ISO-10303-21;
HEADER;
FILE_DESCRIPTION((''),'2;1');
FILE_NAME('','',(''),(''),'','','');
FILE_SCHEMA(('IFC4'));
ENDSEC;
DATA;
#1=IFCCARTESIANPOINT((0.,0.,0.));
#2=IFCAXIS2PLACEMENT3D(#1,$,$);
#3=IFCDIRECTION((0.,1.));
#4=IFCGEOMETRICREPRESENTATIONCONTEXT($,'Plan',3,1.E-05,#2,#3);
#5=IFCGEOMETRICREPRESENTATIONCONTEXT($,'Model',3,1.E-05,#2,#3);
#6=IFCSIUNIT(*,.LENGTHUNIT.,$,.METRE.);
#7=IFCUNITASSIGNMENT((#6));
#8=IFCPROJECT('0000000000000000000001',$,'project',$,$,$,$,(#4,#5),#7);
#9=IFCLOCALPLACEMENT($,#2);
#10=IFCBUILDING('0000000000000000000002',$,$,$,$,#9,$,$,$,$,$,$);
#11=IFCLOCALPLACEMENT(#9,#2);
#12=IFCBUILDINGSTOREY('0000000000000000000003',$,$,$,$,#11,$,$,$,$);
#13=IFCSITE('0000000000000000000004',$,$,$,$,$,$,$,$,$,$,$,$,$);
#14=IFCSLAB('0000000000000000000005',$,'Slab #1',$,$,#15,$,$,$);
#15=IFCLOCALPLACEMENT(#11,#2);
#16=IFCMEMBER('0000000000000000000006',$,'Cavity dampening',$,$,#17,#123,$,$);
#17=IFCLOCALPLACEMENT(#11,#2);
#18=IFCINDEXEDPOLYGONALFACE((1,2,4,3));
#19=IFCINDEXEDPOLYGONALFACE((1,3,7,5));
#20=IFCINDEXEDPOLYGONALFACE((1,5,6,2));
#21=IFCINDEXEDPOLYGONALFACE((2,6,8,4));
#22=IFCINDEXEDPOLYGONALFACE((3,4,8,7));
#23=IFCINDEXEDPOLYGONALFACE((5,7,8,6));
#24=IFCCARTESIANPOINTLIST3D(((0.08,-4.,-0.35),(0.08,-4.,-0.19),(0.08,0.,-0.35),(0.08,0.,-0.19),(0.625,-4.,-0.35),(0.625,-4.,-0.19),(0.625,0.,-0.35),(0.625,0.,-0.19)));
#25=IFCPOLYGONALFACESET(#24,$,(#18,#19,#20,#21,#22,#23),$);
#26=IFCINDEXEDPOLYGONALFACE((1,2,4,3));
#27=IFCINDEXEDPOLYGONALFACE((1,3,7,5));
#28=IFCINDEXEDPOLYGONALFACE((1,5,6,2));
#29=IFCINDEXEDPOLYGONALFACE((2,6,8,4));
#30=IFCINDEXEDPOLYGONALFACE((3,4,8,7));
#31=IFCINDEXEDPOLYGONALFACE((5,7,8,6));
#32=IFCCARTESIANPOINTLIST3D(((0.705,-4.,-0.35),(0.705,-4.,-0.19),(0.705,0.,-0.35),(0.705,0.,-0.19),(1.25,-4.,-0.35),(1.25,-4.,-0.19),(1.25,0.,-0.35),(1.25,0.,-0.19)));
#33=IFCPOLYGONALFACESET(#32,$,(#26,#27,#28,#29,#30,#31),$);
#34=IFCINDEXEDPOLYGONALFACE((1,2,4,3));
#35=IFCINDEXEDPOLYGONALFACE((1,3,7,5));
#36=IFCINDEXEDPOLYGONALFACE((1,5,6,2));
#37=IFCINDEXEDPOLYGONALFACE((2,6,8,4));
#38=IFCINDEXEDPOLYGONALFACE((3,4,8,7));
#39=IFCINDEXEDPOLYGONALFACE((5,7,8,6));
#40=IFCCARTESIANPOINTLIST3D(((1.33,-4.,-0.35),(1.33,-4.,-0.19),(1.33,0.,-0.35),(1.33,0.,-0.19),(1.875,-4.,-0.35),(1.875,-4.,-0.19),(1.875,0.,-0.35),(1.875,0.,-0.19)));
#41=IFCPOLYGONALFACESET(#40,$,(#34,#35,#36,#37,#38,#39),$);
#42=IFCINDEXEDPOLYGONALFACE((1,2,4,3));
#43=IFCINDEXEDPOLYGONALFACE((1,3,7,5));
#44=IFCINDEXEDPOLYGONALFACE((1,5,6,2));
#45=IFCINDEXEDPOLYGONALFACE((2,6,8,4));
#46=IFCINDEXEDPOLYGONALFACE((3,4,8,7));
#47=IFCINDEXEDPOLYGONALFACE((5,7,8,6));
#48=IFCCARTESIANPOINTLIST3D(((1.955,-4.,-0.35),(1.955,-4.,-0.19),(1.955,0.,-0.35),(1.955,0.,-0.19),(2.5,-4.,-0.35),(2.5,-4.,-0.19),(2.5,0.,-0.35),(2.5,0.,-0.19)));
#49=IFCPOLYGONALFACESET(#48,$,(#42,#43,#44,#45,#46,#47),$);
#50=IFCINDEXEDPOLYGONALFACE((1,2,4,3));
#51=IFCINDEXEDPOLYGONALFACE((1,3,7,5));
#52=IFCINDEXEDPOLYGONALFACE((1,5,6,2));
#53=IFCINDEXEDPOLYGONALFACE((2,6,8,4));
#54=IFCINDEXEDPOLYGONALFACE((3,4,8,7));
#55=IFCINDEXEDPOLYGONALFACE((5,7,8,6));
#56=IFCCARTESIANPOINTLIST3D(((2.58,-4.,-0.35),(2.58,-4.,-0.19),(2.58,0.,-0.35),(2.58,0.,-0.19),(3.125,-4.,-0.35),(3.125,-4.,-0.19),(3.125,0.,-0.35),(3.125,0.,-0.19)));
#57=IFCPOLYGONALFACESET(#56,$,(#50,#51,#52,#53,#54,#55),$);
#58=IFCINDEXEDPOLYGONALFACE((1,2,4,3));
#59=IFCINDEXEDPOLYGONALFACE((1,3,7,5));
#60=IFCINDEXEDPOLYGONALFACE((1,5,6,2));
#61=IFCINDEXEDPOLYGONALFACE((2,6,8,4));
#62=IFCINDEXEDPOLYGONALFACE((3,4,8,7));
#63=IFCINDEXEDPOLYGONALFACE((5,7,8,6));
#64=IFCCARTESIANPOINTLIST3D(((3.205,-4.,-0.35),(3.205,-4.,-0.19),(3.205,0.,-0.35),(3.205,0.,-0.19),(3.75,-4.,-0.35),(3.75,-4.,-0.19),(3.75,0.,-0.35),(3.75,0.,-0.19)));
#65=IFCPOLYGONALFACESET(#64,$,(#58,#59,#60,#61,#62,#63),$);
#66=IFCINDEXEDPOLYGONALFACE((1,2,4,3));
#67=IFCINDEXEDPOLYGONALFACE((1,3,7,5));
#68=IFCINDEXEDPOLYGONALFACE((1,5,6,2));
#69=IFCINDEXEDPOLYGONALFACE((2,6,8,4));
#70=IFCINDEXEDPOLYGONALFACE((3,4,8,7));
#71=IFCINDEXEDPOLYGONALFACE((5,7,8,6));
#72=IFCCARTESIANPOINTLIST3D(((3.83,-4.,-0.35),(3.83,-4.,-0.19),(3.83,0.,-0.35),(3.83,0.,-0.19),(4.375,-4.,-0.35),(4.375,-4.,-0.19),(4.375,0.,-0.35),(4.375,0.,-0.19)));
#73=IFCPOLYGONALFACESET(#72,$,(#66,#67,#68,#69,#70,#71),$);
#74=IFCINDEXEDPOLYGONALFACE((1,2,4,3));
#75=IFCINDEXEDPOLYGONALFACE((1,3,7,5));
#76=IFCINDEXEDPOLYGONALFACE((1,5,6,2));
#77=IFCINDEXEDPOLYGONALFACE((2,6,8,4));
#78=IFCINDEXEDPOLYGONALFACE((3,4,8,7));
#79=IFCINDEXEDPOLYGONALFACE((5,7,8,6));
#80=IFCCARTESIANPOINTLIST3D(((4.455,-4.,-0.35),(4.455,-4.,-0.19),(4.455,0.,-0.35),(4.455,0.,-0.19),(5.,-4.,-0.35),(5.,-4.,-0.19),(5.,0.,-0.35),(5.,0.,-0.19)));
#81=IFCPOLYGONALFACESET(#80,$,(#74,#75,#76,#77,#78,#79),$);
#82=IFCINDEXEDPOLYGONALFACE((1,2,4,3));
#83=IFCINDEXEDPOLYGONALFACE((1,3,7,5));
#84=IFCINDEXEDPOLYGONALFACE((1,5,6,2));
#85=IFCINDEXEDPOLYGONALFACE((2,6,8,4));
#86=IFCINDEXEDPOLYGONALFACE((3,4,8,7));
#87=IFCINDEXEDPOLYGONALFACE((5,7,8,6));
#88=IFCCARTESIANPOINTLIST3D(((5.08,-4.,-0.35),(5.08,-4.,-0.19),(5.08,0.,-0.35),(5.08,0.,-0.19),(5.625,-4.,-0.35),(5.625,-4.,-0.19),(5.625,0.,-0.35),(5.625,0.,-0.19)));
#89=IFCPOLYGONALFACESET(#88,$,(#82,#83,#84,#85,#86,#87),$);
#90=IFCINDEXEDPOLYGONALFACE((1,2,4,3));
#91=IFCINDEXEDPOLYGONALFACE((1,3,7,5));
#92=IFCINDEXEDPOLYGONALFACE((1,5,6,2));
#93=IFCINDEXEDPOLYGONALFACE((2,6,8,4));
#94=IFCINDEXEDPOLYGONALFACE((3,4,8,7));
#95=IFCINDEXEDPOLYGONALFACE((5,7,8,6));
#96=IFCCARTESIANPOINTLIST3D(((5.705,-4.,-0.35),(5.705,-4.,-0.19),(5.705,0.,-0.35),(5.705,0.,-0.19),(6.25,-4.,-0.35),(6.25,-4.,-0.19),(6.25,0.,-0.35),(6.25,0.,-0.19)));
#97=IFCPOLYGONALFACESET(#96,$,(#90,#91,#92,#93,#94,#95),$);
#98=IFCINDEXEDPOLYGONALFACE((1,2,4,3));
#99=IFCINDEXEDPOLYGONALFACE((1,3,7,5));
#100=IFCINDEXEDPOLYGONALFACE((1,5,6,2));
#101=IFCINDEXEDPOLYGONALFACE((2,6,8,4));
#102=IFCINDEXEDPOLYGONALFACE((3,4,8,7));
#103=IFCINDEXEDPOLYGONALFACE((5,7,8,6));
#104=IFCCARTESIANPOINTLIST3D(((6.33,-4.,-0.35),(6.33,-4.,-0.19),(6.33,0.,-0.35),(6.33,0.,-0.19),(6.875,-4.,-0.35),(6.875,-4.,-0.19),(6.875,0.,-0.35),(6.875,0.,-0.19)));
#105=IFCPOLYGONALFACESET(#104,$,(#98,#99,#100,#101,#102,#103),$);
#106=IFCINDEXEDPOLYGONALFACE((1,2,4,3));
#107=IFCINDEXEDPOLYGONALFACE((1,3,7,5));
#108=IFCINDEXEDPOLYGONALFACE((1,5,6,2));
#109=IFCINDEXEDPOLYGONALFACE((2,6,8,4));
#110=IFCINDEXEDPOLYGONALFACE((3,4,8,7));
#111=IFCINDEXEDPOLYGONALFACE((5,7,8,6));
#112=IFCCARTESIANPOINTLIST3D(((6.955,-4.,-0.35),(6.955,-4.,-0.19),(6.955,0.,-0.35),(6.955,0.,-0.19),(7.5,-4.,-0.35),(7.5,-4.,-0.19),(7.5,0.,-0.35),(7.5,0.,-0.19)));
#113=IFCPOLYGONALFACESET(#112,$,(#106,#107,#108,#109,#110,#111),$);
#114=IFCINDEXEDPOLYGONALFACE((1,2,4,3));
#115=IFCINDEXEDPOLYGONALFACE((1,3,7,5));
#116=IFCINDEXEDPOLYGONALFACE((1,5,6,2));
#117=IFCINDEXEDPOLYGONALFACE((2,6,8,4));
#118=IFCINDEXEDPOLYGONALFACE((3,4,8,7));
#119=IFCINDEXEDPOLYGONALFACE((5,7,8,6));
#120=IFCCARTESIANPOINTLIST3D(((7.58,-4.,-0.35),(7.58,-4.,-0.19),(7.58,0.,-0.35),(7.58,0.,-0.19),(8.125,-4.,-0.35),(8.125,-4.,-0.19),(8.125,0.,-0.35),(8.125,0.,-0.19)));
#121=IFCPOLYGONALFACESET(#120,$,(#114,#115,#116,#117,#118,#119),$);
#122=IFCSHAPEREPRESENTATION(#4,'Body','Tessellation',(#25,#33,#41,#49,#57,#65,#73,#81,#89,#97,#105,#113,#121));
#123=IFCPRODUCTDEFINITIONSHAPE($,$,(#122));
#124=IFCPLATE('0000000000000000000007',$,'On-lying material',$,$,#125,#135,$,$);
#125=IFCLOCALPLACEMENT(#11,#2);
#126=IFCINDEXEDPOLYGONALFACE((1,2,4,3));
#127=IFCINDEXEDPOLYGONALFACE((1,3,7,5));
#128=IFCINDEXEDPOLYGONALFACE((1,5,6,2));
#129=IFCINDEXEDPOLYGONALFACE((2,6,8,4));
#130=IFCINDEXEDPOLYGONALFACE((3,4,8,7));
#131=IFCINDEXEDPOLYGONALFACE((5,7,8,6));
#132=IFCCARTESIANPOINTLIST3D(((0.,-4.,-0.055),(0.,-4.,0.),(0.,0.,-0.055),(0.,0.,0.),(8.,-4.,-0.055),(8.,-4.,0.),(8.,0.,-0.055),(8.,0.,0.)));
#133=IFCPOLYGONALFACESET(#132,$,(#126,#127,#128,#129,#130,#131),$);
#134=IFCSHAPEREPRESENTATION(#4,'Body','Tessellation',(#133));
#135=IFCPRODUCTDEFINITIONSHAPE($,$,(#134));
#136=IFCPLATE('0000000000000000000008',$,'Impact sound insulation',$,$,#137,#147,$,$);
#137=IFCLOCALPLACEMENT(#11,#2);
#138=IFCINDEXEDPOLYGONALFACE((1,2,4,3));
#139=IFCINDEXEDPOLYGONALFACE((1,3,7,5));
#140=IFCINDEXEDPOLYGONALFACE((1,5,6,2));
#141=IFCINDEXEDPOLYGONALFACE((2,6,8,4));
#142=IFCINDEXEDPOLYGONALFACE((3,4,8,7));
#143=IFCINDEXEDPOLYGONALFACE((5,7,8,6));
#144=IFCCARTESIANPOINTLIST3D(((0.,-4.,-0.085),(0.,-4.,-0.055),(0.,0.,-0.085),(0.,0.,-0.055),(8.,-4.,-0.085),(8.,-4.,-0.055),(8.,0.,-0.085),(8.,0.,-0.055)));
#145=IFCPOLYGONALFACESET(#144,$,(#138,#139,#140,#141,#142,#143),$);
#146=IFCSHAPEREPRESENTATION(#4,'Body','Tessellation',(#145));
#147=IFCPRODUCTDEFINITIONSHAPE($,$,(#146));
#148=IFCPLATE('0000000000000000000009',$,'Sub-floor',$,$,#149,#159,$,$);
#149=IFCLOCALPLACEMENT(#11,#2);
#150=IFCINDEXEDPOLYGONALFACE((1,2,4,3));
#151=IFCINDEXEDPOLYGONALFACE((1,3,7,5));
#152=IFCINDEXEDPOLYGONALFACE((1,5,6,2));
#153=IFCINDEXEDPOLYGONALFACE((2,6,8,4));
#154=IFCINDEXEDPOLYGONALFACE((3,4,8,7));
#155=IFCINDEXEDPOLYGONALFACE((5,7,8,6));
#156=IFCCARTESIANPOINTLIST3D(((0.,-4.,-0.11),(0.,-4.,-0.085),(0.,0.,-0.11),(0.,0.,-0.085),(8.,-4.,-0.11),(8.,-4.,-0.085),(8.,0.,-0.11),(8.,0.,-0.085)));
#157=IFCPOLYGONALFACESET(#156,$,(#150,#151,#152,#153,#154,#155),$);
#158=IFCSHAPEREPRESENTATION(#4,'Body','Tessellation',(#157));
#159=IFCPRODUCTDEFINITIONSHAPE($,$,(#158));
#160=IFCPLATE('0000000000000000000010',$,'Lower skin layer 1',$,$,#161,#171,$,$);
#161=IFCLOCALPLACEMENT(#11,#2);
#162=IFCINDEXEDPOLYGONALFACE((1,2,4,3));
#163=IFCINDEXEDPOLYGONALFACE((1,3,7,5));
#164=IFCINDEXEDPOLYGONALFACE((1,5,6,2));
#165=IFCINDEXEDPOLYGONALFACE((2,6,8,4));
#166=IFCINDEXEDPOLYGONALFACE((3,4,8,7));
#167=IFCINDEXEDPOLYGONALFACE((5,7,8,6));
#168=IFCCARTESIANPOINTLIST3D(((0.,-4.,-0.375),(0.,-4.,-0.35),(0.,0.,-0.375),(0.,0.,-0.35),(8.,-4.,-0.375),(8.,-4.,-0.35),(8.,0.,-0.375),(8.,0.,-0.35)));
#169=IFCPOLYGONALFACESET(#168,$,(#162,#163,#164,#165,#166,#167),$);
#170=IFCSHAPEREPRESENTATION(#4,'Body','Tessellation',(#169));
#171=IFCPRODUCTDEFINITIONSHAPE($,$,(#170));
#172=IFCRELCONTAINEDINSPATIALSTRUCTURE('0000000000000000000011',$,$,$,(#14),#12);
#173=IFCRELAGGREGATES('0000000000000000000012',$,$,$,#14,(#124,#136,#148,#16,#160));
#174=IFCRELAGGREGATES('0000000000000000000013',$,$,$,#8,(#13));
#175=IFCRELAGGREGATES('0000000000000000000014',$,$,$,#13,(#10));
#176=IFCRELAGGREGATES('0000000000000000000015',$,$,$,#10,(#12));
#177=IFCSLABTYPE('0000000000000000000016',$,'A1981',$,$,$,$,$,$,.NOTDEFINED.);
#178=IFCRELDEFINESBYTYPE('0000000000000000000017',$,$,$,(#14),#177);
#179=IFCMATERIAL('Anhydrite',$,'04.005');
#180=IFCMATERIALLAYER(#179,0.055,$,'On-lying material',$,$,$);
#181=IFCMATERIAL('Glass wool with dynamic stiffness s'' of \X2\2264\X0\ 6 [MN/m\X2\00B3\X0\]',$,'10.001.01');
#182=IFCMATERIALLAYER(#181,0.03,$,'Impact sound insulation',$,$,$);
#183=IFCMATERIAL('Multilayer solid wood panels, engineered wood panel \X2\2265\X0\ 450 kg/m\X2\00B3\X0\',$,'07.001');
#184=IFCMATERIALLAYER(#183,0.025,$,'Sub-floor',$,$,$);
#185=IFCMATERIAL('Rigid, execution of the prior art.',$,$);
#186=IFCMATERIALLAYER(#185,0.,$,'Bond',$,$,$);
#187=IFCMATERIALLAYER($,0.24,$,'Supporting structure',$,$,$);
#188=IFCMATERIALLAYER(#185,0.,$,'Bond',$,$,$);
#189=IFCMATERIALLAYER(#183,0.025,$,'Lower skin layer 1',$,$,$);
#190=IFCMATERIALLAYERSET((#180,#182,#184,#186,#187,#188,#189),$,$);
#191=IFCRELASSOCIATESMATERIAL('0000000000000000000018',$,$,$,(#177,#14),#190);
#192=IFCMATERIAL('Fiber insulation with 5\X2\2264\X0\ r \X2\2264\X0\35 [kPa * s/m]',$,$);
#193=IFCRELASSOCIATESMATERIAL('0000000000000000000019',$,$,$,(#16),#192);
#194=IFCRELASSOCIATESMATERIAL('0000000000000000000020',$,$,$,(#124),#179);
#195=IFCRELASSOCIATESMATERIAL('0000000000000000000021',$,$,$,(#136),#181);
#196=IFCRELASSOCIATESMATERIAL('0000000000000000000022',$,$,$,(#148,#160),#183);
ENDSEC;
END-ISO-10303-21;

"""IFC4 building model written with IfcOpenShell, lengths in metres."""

from ifc_helpers import new_model, si_unit, direction, frame, frame_2d, origin, origin_with_axes, place, context, project, spatial, rectangle, extrude, material, layer, layer_set, type_object, element, aggregate, save


model = new_model("IFC4")

# Units and contexts
plan_context = context("Plan", 3, precision=1e-05, world=origin(), true_north=direction((0.0, 1.0)))
model_context = context("Model", 3, precision=1e-05, world=origin(), true_north=direction((0.0, 1.0)))
ifc_project = project(units=[si_unit("LENGTHUNIT", "METRE")], contexts=[plan_context, model_context])

# Site, building, storey
site = spatial("IfcSite", under=ifc_project)
building_placement = place(None, origin())
building = spatial("IfcBuilding", under=site, at=building_placement)
storey_placement = place(building_placement, origin())
storey = spatial("IfcBuildingStorey", under=building, at=storey_placement)

# Slab, member, plates
ifc_material_1 = material(Name="Anhydrite", Category="04.005")
ifc_layer_1 = layer(ifc_material_1, 0.055, Name="On-lying material")
ifc_material_2 = material(Name="Glass wool with dynamic stiffness s' of ≤ 6 [MN/m³]", Category="10.001.01")
ifc_layer_2 = layer(ifc_material_2, 0.03, Name="Impact sound insulation")
ifc_material_3 = material(Name="Multilayer solid wood panels, engineered wood panel ≥ 450 kg/m³", Category="07.001")
ifc_layer_3 = layer(ifc_material_3, 0.025, Name="Sub-floor")
ifc_material_4 = material(Name="Rigid, execution of the prior art.")
ifc_layer_4 = layer(ifc_material_4, 0.0, Name="Bond")
ifc_layer_5 = layer(None, 0.24, Name="Supporting structure")
ifc_layer_6 = layer(ifc_material_4, 0.0, Name="Bond")
ifc_layer_7 = layer(ifc_material_3, 0.025, Name="Lower skin layer 1")
ifc_layer_set = layer_set([ifc_layer_1, ifc_layer_2, ifc_layer_3, ifc_layer_4, ifc_layer_5, ifc_layer_6, ifc_layer_7])
slab_type = type_object("IfcSlabType", Name="A1981", PredefinedType="NOTDEFINED", material=ifc_layer_set)
slab_placement = place(None, frame((0.0, 0.0, 0.0), z_axis=(0.0, 0.0, -1.0), x_axis=(1.0, 0.0, 0.0)))
slab = element("IfcSlab", 1, at=slab_placement, inside=storey, type_object=slab_type, material=ifc_layer_set, Name="Slab #1")
ifc_material_5 = material(Name="Fiber insulation with 5≤ r ≤35 [kPa * s/m]")
member_1_placement = place(slab_placement, origin())
member_1 = element("IfcMember", 2, at=member_1_placement, material=ifc_material_5, Name="Cavity dampening", context=plan_context, shape_type="SweptSolid", body=[
    extrude(rectangle(XDim=0.545, YDim=0.16, at=frame_2d((0.2725, 0.08), x_axis=(1.0, 0.0))), frame((0.08, 4.0, 0.19), z_axis=(0.0, -1.0, 0.0), x_axis=(1.0, 0.0, 0.0)), (0.0, 0.0, 1.0), 4.0),
    extrude(rectangle(XDim=0.545, YDim=0.16, at=frame_2d((0.2725, 0.08), x_axis=(1.0, 0.0))), frame((0.705, 4.0, 0.19), z_axis=(0.0, -1.0, 0.0), x_axis=(1.0, 0.0, 0.0)), (0.0, 0.0, 1.0), 4.0),
    extrude(rectangle(XDim=0.545, YDim=0.16, at=frame_2d((0.2725, 0.08), x_axis=(1.0, 0.0))), frame((1.33, 4.0, 0.19), z_axis=(0.0, -1.0, 0.0), x_axis=(1.0, 0.0, 0.0)), (0.0, 0.0, 1.0), 4.0),
    extrude(rectangle(XDim=0.545, YDim=0.16, at=frame_2d((0.2725, 0.08), x_axis=(1.0, 0.0))), frame((1.955, 4.0, 0.19), z_axis=(0.0, -1.0, 0.0), x_axis=(1.0, 0.0, 0.0)), (0.0, 0.0, 1.0), 4.0),
    extrude(rectangle(XDim=0.545, YDim=0.16, at=frame_2d((0.2725, 0.08), x_axis=(1.0, 0.0))), frame((2.58, 4.0, 0.19), z_axis=(0.0, -1.0, 0.0), x_axis=(1.0, 0.0, 0.0)), (0.0, 0.0, 1.0), 4.0),
    extrude(rectangle(XDim=0.545, YDim=0.16, at=frame_2d((0.2725, 0.08), x_axis=(1.0, 0.0))), frame((3.205, 4.0, 0.19), z_axis=(0.0, -1.0, 0.0), x_axis=(1.0, 0.0, 0.0)), (0.0, 0.0, 1.0), 4.0),
    extrude(rectangle(XDim=0.545, YDim=0.16, at=frame_2d((0.2725, 0.08), x_axis=(1.0, 0.0))), frame((3.83, 4.0, 0.19), z_axis=(0.0, -1.0, 0.0), x_axis=(1.0, 0.0, 0.0)), (0.0, 0.0, 1.0), 4.0),
    extrude(rectangle(XDim=0.545, YDim=0.16, at=frame_2d((0.2725, 0.08), x_axis=(1.0, 0.0))), frame((4.455, 4.0, 0.19), z_axis=(0.0, -1.0, 0.0), x_axis=(1.0, 0.0, 0.0)), (0.0, 0.0, 1.0), 4.0),
    extrude(rectangle(XDim=0.545, YDim=0.16, at=frame_2d((0.2725, 0.08), x_axis=(1.0, 0.0))), frame((5.08, 4.0, 0.19), z_axis=(0.0, -1.0, 0.0), x_axis=(1.0, 0.0, 0.0)), (0.0, 0.0, 1.0), 4.0),
    extrude(rectangle(XDim=0.545, YDim=0.16, at=frame_2d((0.2725, 0.08), x_axis=(1.0, 0.0))), frame((5.705, 4.0, 0.19), z_axis=(0.0, -1.0, 0.0), x_axis=(1.0, 0.0, 0.0)), (0.0, 0.0, 1.0), 4.0),
    extrude(rectangle(XDim=0.545, YDim=0.16, at=frame_2d((0.2725, 0.08), x_axis=(1.0, 0.0))), frame((6.33, 4.0, 0.19), z_axis=(0.0, -1.0, 0.0), x_axis=(1.0, 0.0, 0.0)), (0.0, 0.0, 1.0), 4.0),
    extrude(rectangle(XDim=0.545, YDim=0.16, at=frame_2d((0.2725, 0.08), x_axis=(1.0, 0.0))), frame((6.955, 4.0, 0.19), z_axis=(0.0, -1.0, 0.0), x_axis=(1.0, 0.0, 0.0)), (0.0, 0.0, 1.0), 4.0),
    extrude(rectangle(XDim=0.545, YDim=0.16, at=frame_2d((0.2725, 0.08), x_axis=(1.0, 0.0))), frame((7.58, 4.0, 0.19), z_axis=(0.0, -1.0, 0.0), x_axis=(1.0, 0.0, 0.0)), (0.0, 0.0, 1.0), 4.0),
])
plate_1_placement = place(slab_placement, origin())
plate_1 = element("IfcPlate", 3, at=plate_1_placement, material=ifc_material_1, Name="On-lying material", context=plan_context, shape_type="SweptSolid", body=[
    extrude(rectangle(XDim=8.0, YDim=4.0, at=frame_2d((4.0, 2.0), x_axis=(1.0, 0.0))), origin_with_axes(), (0.0, 0.0, 1.0), 0.055),
])
plate_2_placement = place(slab_placement, origin())
plate_2 = element("IfcPlate", 4, at=plate_2_placement, material=ifc_material_2, Name="Impact sound insulation", context=plan_context, shape_type="SweptSolid", body=[
    extrude(rectangle(XDim=8.0, YDim=4.0, at=frame_2d((4.0, 2.0), x_axis=(1.0, 0.0))), frame((0.0, 0.0, 0.055), z_axis=(0.0, 0.0, 1.0), x_axis=(1.0, 0.0, 0.0)), (0.0, 0.0, 1.0), 0.03),
])
plate_3_placement = place(slab_placement, origin())
plate_3 = element("IfcPlate", 5, at=plate_3_placement, material=ifc_material_3, Name="Sub-floor", context=plan_context, shape_type="SweptSolid", body=[
    extrude(rectangle(XDim=8.0, YDim=4.0, at=frame_2d((4.0, 2.0), x_axis=(1.0, 0.0))), frame((0.0, 0.0, 0.085), z_axis=(0.0, 0.0, 1.0), x_axis=(1.0, 0.0, 0.0)), (0.0, 0.0, 1.0), 0.025),
])
plate_4_placement = place(slab_placement, origin())
plate_4 = element("IfcPlate", 6, at=plate_4_placement, material=ifc_material_3, Name="Lower skin layer 1", context=plan_context, shape_type="SweptSolid", body=[
    extrude(rectangle(XDim=8.0, YDim=4.0, at=frame_2d((4.0, 2.0), x_axis=(1.0, 0.0))), frame((0.0, 0.0, 0.35), z_axis=(0.0, 0.0, 1.0), x_axis=(1.0, 0.0, 0.0)), (0.0, 0.0, 1.0), 0.025),
])
aggregate(slab, [plate_1, plate_2, plate_3, member_1, plate_4])

save(model, "model.ifc")
